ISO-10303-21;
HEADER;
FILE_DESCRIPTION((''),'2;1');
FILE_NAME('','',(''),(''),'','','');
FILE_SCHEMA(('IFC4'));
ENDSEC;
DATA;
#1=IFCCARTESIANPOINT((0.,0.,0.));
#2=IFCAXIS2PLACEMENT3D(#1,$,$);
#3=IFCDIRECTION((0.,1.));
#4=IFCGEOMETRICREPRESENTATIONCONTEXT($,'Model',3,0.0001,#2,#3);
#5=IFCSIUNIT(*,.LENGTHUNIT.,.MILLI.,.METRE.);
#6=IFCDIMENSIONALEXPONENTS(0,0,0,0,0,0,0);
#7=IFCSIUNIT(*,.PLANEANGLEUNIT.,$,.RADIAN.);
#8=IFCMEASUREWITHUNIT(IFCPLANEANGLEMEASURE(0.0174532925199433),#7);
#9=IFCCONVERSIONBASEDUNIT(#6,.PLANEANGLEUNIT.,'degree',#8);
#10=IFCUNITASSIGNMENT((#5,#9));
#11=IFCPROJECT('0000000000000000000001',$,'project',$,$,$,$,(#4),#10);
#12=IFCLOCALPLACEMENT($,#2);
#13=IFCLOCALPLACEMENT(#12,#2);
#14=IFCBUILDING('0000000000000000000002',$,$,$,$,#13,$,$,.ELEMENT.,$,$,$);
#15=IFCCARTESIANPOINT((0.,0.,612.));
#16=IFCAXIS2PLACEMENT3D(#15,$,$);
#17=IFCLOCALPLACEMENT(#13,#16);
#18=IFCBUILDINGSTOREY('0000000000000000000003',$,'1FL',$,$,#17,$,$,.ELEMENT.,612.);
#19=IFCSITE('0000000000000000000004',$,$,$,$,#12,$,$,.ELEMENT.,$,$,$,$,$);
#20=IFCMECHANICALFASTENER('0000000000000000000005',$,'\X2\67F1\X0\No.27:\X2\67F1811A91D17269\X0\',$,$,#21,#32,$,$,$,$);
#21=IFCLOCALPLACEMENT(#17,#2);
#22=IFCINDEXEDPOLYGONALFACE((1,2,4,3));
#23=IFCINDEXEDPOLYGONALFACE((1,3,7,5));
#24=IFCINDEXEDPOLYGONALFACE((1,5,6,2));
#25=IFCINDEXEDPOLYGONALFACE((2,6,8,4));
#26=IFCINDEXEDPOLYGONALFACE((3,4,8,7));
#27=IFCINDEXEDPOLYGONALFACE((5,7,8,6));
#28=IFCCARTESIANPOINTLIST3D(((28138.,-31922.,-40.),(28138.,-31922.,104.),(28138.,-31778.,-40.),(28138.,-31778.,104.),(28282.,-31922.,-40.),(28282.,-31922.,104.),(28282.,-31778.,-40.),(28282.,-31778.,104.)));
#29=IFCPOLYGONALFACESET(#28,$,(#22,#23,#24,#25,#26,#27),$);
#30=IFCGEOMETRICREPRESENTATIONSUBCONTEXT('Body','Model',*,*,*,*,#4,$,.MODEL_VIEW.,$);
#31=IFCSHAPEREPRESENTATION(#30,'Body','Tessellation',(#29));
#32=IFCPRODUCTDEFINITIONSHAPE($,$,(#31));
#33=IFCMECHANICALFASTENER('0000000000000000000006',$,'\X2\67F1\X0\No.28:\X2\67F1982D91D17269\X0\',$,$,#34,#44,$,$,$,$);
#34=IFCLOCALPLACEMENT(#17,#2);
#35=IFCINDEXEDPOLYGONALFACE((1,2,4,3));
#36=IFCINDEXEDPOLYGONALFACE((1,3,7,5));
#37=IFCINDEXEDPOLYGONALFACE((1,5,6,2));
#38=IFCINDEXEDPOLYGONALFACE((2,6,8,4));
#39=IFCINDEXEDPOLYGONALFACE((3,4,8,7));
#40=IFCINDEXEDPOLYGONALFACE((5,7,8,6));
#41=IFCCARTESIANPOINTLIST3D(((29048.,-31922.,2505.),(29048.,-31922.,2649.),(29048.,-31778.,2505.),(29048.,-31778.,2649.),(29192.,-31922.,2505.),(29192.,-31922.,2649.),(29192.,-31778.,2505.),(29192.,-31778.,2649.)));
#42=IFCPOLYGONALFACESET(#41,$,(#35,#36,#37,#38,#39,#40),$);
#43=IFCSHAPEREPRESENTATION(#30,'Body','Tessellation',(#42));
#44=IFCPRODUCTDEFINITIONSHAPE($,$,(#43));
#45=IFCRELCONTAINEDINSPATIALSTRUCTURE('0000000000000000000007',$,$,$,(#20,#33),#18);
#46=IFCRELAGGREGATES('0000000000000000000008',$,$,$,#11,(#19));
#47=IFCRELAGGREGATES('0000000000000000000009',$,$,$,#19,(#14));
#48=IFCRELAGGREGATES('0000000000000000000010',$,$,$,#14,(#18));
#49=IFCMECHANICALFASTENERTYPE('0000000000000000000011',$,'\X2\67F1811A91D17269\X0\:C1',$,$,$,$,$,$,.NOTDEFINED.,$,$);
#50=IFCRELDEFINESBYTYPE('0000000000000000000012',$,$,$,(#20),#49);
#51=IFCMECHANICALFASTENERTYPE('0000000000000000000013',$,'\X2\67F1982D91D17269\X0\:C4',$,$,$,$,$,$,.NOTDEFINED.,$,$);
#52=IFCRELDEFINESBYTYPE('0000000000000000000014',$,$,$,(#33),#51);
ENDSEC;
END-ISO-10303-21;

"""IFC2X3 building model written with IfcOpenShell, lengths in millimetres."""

from ifc_helpers import new_model, entity, si_unit, converted_unit, direction, frame, origin, origin_with_axes, origin_2d, place, context, subcontext, project, spatial, rectangle, extrude, type_object, element, save


model = new_model("IFC2X3")

# Units and contexts
model_context = context("Model", 3, precision=0.0001, world=origin(), true_north=direction((0.0, 1.0)))
body_context = subcontext(model_context, "Body", "Model", "MODEL_VIEW")
ifc_project = project(units=[si_unit("LENGTHUNIT", "METRE", prefix="MILLI"), converted_unit("PLANEANGLEUNIT", "degree", entity("IfcPlaneAngleMeasure", 0.0174532925199433), si_unit("PLANEANGLEUNIT", "RADIAN"), dimensions=[0, 0, 0, 0, 0, 0, 0])], contexts=[model_context])

# Site, building, storey
site_placement = place(None, origin())
site = spatial("IfcSite", under=ifc_project, at=site_placement, CompositionType="ELEMENT")
building_placement = place(site_placement, origin())
building = spatial("IfcBuilding", under=site, at=building_placement, CompositionType="ELEMENT")
storey_placement = place(building_placement, frame((0.0, 0.0, 612.0)))
storey = spatial("IfcBuildingStorey", under=building, at=storey_placement, Name="1FL", CompositionType="ELEMENT", Elevation=612.0)

# Mechanical fasteners
mechanical_fastener_type_1 = type_object("IfcMechanicalFastenerType", Name="柱脚金物:C1")
mechanical_fastener_1_placement = place(storey_placement, frame((28210.0, -31850.0, -40.0)))
element("IfcMechanicalFastener", 1, at=mechanical_fastener_1_placement, inside=storey, type_object=mechanical_fastener_type_1, Name="柱No.27:柱脚金物", context=body_context, shape_type="SweptSolid", body=[
    extrude(rectangle(XDim=144.0, YDim=144.0, at=origin_2d()), origin_with_axes(), (0.0, 0.0, 1.0), 144.0),
])
mechanical_fastener_type_2 = type_object("IfcMechanicalFastenerType", Name="柱頭金物:C4")
mechanical_fastener_2_placement = place(storey_placement, frame((29120.0, -31850.0, 2505.0)))
element("IfcMechanicalFastener", 2, at=mechanical_fastener_2_placement, inside=storey, type_object=mechanical_fastener_type_2, Name="柱No.28:柱頭金物", context=body_context, shape_type="SweptSolid", body=[
    extrude(rectangle(XDim=144.0, YDim=144.0, at=origin_2d()), origin_with_axes(), (0.0, 0.0, 1.0), 144.0),
])

save(model, "model.ifc")
